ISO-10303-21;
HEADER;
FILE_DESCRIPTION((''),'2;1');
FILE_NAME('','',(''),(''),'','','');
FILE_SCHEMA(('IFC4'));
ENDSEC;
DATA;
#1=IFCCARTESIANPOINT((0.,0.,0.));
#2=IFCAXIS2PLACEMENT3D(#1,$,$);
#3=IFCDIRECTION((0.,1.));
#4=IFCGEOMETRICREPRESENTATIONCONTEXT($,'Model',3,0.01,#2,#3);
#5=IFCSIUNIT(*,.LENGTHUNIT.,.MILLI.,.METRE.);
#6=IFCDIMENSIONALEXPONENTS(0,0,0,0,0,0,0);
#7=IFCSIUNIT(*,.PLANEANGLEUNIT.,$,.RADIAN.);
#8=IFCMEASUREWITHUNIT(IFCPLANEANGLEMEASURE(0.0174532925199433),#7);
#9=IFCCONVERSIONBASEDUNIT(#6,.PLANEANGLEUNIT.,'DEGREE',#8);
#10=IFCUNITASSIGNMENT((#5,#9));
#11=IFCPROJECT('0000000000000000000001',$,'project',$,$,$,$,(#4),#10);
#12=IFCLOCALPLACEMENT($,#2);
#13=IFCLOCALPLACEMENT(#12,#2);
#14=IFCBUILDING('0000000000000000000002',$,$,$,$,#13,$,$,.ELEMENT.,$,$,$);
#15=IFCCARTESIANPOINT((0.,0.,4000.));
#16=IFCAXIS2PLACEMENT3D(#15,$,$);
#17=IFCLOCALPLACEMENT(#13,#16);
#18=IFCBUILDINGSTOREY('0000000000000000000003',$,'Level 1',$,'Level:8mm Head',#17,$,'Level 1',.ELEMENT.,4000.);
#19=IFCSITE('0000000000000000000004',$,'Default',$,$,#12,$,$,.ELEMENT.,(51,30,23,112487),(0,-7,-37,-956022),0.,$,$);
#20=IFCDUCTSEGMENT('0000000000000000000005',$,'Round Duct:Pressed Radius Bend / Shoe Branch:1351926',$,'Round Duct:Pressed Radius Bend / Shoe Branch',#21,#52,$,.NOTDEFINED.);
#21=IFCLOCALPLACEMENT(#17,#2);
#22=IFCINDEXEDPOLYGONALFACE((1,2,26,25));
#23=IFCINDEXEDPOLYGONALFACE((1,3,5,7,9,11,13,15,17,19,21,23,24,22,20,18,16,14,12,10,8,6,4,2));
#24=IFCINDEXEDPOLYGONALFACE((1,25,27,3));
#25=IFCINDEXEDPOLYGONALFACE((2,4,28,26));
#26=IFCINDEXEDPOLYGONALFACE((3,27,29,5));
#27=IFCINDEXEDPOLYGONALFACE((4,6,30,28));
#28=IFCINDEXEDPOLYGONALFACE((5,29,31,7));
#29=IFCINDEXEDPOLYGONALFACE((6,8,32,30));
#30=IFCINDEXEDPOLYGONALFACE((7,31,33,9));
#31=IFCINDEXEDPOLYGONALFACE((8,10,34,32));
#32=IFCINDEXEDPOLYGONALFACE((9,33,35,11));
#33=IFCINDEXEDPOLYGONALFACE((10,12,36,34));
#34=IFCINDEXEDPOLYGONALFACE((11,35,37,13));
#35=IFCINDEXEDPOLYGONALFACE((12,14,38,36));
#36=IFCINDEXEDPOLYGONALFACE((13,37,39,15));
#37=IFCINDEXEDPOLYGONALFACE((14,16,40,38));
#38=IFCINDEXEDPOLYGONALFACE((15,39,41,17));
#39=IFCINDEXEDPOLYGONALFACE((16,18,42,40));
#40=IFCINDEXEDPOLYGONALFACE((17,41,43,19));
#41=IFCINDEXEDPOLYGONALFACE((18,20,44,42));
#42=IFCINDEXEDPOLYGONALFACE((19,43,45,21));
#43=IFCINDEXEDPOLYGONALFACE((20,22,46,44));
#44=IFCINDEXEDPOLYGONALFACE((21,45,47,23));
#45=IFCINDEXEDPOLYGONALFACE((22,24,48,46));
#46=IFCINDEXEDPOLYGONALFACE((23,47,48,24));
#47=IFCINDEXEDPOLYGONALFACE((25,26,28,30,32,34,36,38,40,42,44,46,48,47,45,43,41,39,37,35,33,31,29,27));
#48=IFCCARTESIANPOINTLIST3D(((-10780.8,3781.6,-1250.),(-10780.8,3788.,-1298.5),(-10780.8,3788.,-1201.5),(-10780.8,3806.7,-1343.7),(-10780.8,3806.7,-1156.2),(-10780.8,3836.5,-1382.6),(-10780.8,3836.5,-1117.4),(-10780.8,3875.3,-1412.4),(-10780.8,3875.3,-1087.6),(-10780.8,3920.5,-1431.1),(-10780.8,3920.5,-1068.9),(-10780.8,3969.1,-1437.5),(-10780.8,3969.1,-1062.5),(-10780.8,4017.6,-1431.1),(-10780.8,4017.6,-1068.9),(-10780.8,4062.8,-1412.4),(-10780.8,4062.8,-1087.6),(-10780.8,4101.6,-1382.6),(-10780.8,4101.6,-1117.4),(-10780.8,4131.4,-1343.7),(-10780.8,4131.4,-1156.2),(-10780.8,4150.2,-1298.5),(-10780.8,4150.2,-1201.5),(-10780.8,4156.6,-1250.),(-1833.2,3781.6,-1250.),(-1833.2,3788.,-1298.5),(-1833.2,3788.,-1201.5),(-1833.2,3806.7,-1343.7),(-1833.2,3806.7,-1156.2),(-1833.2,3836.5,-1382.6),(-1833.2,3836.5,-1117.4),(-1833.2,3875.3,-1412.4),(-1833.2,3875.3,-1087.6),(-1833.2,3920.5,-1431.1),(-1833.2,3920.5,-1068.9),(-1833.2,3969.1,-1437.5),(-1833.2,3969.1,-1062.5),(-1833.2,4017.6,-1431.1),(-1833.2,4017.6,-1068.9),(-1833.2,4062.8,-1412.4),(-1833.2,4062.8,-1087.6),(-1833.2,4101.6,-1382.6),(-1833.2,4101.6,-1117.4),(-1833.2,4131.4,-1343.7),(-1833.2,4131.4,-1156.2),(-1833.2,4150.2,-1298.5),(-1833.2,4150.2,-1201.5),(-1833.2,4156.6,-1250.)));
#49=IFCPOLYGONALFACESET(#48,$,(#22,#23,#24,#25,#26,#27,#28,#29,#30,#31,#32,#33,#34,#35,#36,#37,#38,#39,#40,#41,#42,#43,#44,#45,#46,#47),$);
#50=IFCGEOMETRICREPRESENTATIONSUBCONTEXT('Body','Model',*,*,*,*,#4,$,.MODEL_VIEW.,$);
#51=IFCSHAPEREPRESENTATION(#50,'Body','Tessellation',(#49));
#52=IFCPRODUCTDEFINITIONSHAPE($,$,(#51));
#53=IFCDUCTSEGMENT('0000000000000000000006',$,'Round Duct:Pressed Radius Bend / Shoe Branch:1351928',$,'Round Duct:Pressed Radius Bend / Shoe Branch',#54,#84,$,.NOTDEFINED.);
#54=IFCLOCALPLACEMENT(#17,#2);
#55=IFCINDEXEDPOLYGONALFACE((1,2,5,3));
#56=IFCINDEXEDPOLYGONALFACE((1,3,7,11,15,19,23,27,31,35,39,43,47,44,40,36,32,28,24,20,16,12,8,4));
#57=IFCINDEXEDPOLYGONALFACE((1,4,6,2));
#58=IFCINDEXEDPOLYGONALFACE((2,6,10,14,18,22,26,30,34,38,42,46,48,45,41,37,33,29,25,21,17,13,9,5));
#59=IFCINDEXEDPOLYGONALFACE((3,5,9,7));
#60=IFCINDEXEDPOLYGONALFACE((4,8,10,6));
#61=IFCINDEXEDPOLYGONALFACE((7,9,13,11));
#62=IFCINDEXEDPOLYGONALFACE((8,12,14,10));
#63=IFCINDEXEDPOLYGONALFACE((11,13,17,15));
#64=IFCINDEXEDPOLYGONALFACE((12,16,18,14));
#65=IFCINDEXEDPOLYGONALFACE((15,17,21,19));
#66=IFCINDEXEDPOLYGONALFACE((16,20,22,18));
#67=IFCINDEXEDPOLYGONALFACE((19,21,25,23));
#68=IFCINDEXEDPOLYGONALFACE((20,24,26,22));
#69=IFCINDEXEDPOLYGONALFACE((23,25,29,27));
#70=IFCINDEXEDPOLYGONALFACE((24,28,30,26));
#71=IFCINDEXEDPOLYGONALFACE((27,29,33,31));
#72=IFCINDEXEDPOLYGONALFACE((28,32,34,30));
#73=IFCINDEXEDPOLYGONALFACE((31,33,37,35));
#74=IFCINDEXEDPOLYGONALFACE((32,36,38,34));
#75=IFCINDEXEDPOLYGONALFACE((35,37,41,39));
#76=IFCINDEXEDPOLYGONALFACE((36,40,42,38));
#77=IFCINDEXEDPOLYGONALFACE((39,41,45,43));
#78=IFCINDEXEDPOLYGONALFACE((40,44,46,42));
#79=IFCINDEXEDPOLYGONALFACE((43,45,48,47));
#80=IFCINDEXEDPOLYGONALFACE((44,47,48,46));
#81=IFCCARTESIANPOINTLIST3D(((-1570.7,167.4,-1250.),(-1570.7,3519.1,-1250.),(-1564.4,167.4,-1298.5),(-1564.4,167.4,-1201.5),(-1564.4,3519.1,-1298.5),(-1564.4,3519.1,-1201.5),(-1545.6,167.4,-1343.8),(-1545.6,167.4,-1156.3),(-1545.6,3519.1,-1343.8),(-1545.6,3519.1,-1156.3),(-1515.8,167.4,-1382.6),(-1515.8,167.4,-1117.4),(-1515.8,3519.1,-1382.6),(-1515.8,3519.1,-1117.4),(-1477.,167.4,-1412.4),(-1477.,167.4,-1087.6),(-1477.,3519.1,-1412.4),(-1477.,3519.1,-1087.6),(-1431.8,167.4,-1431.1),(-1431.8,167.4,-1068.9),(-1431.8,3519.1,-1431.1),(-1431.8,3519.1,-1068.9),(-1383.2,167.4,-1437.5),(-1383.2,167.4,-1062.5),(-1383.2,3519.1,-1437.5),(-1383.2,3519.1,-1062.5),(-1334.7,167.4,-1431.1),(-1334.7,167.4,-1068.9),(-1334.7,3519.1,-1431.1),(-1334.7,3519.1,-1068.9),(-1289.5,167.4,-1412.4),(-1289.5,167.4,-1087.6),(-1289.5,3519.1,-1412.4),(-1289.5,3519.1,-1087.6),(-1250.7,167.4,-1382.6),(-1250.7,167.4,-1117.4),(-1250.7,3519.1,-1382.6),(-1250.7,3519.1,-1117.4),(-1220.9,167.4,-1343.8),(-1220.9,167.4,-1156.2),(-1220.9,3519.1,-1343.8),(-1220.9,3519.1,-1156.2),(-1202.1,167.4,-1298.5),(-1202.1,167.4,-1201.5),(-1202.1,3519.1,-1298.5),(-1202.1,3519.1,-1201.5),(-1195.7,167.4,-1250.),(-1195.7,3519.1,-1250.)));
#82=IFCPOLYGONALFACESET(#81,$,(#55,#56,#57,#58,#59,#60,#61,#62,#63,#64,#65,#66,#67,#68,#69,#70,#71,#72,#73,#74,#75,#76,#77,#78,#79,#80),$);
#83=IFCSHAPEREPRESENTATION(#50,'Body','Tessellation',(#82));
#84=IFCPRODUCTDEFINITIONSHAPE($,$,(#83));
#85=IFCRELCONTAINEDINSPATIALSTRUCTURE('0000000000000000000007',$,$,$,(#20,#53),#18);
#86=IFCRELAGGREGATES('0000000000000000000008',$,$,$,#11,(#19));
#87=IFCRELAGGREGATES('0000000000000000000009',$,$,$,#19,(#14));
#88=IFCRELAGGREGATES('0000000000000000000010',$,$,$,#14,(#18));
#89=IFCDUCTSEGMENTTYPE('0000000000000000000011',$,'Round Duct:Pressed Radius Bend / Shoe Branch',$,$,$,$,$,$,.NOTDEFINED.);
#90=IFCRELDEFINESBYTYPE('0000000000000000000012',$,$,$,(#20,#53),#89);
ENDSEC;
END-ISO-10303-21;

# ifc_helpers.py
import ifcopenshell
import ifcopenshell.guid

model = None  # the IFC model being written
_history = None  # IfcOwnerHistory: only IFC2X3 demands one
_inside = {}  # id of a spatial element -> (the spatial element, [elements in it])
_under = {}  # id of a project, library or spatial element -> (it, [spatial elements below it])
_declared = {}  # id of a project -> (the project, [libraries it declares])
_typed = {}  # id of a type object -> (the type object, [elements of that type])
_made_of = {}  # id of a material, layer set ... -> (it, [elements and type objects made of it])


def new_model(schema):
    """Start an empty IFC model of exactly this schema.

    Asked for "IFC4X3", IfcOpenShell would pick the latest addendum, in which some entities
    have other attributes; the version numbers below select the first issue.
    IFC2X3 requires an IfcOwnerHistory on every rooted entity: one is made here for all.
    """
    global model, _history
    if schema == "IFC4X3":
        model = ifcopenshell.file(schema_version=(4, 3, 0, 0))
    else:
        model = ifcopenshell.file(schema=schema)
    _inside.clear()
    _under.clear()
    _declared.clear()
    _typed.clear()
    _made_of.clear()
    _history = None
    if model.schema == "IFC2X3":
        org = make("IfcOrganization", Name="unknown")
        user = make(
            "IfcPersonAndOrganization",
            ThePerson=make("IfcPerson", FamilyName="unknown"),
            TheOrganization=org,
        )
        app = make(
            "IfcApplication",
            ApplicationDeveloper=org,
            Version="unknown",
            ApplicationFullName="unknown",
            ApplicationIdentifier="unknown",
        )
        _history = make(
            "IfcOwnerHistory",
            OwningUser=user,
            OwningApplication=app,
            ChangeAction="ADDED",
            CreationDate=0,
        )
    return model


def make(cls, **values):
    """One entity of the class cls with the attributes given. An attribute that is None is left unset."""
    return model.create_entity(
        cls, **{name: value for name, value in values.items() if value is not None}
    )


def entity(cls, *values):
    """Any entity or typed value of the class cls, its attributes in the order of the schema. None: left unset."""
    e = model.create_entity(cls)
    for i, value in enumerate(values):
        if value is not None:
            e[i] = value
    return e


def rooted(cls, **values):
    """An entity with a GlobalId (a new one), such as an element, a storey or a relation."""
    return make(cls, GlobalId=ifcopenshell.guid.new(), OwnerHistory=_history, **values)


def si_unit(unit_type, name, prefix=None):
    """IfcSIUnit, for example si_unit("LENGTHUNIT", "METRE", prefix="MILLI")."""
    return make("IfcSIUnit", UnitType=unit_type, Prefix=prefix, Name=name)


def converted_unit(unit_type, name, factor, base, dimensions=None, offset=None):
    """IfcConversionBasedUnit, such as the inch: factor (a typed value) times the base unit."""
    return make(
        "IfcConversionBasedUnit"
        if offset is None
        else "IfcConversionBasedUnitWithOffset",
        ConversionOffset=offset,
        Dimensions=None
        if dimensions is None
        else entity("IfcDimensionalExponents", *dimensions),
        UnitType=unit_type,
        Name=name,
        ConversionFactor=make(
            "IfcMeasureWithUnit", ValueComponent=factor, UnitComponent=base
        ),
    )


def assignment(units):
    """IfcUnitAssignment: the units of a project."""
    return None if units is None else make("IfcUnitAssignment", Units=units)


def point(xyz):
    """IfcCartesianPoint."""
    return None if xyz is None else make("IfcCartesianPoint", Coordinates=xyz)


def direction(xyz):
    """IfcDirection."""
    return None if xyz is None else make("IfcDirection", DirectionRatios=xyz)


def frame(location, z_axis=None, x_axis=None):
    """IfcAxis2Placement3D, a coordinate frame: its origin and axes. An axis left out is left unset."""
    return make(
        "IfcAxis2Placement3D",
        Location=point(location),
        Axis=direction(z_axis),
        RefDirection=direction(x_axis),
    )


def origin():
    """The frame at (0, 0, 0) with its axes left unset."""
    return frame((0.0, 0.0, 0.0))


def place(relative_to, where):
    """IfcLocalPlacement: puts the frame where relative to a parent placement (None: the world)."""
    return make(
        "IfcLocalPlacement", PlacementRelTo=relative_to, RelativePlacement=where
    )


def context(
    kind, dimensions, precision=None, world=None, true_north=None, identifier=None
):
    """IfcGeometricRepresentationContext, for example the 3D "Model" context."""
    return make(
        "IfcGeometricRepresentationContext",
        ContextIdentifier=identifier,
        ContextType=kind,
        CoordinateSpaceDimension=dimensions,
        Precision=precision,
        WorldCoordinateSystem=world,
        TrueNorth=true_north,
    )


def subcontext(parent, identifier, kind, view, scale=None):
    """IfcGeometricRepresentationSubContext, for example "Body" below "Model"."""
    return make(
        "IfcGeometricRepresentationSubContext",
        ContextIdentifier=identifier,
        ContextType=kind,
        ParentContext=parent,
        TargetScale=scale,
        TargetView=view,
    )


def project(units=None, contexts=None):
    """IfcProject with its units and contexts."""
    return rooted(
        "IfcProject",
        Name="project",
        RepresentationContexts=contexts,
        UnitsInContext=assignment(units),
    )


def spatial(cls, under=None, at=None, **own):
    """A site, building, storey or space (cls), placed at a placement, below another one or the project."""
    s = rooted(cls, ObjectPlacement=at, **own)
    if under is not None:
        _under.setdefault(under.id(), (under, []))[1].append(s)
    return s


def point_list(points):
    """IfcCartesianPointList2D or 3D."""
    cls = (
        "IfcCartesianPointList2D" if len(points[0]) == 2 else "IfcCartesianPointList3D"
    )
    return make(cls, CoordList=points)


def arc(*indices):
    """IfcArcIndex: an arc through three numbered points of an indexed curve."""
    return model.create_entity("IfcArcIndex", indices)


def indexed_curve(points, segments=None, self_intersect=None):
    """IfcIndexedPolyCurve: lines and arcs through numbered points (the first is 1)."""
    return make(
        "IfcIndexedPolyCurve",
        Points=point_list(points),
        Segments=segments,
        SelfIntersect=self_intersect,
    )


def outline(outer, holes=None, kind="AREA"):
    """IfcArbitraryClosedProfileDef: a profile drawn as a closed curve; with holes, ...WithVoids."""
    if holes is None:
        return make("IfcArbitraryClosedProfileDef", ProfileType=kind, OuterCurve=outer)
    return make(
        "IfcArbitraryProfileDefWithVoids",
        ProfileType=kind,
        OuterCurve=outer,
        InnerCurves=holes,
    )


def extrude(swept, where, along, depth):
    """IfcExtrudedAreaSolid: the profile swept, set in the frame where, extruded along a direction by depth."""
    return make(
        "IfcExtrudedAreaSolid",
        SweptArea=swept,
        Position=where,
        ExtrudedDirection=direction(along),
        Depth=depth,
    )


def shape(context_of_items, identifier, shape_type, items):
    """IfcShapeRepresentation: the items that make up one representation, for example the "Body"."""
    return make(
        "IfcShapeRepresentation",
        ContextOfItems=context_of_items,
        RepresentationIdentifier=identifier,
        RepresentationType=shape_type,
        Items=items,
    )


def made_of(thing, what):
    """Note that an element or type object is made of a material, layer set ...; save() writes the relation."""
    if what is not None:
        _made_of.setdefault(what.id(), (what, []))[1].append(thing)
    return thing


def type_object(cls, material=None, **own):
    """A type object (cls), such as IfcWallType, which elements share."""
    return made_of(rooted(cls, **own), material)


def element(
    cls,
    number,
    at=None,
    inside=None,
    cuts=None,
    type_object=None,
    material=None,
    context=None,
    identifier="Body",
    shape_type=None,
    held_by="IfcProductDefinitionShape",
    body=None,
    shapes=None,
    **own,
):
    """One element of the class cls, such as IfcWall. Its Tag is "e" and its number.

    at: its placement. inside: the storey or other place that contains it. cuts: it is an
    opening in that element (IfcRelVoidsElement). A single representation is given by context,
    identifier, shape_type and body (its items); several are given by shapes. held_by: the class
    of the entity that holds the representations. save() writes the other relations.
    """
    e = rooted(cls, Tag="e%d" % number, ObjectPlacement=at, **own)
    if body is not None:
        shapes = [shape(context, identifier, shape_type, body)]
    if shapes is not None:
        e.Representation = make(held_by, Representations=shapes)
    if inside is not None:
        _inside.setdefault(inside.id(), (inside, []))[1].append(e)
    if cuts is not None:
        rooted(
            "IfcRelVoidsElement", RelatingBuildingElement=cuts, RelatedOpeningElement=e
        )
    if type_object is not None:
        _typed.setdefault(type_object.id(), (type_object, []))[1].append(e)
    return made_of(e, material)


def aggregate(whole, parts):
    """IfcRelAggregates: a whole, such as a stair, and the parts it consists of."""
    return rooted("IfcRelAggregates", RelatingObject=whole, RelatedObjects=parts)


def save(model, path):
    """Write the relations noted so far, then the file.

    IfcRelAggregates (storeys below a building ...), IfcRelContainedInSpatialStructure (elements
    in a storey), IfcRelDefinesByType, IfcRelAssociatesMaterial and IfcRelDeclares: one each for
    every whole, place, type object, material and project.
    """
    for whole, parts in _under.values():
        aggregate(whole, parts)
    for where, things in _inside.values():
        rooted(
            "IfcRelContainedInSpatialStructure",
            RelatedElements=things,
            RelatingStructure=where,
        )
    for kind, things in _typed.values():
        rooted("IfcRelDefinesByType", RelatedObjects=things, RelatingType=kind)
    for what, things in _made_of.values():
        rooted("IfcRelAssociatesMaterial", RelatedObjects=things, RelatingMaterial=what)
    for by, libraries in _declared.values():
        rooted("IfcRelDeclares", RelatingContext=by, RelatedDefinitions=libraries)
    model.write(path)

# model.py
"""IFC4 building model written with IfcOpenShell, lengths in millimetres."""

from ifc_helpers import new_model, entity, si_unit, converted_unit, direction, frame, origin, place, context, subcontext, project, spatial, arc, indexed_curve, outline, extrude, type_object, element, save


model = new_model("IFC4")

# Units and contexts
model_context = context("Model", 3, precision=0.01, world=origin(), true_north=direction((0.0, 1.0)))
body_context = subcontext(model_context, "Body", "Model", "MODEL_VIEW")
ifc_project = project(units=[si_unit("LENGTHUNIT", "METRE", prefix="MILLI"), converted_unit("PLANEANGLEUNIT", "DEGREE", entity("IfcPlaneAngleMeasure", 0.0174532925199433), si_unit("PLANEANGLEUNIT", "RADIAN"), dimensions=[0, 0, 0, 0, 0, 0, 0])], contexts=[model_context])

# Site, building, storey
site_placement = place(None, origin())
site = spatial("IfcSite", under=ifc_project, at=site_placement, Name="Default", CompositionType="ELEMENT", RefLatitude=(51, 30, 23, 112487), RefLongitude=(0, -7, -37, -956022), RefElevation=0.0)
building_placement = place(site_placement, origin())
building = spatial("IfcBuilding", under=site, at=building_placement, CompositionType="ELEMENT")
storey_placement = place(building_placement, frame((0.0, 0.0, 4000.0)))
storey = spatial("IfcBuildingStorey", under=building, at=storey_placement, Name="Level 1", ObjectType="Level:8mm Head", LongName="Level 1", CompositionType="ELEMENT", Elevation=4000.0)

# Duct segments
duct_segment_type = type_object("IfcDuctSegmentType", Name="Round Duct:Pressed Radius Bend / Shoe Branch", PredefinedType="NOTDEFINED")
duct_segment_1_placement = place(storey_placement, origin())
element("IfcDuctSegment", 1, at=duct_segment_1_placement, inside=storey, type_object=duct_segment_type, Name="Round Duct:Pressed Radius Bend / Shoe Branch:1351926", ObjectType="Round Duct:Pressed Radius Bend / Shoe Branch", PredefinedType="NOTDEFINED", context=body_context, shape_type="SweptSolid", body=[
    extrude(outline(indexed_curve([(187.5, 0.0), (132.6, 132.6), (0.0, 187.5), (-132.6, 132.6), (-187.5, 0.0), (-132.6, -132.6), (0.0, -187.5), (132.6, -132.6)], segments=[arc(1, 2, 3), arc(3, 4, 5), arc(5, 6, 7), arc(7, 8, 1)], self_intersect=False)), frame((-10780.8, 3969.1, -1250.0), z_axis=(1.0, 0.0, 0.0), x_axis=(0.0, -1.0, 0.0)), (0.0, 0.0, 1.0), 8947.6),
])
duct_segment_2_placement = place(storey_placement, origin())
element("IfcDuctSegment", 2, at=duct_segment_2_placement, inside=storey, type_object=duct_segment_type, Name="Round Duct:Pressed Radius Bend / Shoe Branch:1351928", ObjectType="Round Duct:Pressed Radius Bend / Shoe Branch", PredefinedType="NOTDEFINED", context=body_context, shape_type="SweptSolid", body=[
    extrude(outline(indexed_curve([(187.5, 0.0), (132.6, 132.6), (0.0, 187.5), (-132.6, 132.6), (-187.5, 0.0), (-132.6, -132.6), (0.0, -187.5), (132.6, -132.6)], segments=[arc(1, 2, 3), arc(3, 4, 5), arc(5, 6, 7), arc(7, 8, 1)], self_intersect=False)), frame((-1383.2, 167.4, -1250.0), z_axis=(0.0, 1.0, 0.0), x_axis=(1.0, 0.0, 0.0)), (0.0, 0.0, 1.0), 3351.7),
])

save(model, "model.ifc")
